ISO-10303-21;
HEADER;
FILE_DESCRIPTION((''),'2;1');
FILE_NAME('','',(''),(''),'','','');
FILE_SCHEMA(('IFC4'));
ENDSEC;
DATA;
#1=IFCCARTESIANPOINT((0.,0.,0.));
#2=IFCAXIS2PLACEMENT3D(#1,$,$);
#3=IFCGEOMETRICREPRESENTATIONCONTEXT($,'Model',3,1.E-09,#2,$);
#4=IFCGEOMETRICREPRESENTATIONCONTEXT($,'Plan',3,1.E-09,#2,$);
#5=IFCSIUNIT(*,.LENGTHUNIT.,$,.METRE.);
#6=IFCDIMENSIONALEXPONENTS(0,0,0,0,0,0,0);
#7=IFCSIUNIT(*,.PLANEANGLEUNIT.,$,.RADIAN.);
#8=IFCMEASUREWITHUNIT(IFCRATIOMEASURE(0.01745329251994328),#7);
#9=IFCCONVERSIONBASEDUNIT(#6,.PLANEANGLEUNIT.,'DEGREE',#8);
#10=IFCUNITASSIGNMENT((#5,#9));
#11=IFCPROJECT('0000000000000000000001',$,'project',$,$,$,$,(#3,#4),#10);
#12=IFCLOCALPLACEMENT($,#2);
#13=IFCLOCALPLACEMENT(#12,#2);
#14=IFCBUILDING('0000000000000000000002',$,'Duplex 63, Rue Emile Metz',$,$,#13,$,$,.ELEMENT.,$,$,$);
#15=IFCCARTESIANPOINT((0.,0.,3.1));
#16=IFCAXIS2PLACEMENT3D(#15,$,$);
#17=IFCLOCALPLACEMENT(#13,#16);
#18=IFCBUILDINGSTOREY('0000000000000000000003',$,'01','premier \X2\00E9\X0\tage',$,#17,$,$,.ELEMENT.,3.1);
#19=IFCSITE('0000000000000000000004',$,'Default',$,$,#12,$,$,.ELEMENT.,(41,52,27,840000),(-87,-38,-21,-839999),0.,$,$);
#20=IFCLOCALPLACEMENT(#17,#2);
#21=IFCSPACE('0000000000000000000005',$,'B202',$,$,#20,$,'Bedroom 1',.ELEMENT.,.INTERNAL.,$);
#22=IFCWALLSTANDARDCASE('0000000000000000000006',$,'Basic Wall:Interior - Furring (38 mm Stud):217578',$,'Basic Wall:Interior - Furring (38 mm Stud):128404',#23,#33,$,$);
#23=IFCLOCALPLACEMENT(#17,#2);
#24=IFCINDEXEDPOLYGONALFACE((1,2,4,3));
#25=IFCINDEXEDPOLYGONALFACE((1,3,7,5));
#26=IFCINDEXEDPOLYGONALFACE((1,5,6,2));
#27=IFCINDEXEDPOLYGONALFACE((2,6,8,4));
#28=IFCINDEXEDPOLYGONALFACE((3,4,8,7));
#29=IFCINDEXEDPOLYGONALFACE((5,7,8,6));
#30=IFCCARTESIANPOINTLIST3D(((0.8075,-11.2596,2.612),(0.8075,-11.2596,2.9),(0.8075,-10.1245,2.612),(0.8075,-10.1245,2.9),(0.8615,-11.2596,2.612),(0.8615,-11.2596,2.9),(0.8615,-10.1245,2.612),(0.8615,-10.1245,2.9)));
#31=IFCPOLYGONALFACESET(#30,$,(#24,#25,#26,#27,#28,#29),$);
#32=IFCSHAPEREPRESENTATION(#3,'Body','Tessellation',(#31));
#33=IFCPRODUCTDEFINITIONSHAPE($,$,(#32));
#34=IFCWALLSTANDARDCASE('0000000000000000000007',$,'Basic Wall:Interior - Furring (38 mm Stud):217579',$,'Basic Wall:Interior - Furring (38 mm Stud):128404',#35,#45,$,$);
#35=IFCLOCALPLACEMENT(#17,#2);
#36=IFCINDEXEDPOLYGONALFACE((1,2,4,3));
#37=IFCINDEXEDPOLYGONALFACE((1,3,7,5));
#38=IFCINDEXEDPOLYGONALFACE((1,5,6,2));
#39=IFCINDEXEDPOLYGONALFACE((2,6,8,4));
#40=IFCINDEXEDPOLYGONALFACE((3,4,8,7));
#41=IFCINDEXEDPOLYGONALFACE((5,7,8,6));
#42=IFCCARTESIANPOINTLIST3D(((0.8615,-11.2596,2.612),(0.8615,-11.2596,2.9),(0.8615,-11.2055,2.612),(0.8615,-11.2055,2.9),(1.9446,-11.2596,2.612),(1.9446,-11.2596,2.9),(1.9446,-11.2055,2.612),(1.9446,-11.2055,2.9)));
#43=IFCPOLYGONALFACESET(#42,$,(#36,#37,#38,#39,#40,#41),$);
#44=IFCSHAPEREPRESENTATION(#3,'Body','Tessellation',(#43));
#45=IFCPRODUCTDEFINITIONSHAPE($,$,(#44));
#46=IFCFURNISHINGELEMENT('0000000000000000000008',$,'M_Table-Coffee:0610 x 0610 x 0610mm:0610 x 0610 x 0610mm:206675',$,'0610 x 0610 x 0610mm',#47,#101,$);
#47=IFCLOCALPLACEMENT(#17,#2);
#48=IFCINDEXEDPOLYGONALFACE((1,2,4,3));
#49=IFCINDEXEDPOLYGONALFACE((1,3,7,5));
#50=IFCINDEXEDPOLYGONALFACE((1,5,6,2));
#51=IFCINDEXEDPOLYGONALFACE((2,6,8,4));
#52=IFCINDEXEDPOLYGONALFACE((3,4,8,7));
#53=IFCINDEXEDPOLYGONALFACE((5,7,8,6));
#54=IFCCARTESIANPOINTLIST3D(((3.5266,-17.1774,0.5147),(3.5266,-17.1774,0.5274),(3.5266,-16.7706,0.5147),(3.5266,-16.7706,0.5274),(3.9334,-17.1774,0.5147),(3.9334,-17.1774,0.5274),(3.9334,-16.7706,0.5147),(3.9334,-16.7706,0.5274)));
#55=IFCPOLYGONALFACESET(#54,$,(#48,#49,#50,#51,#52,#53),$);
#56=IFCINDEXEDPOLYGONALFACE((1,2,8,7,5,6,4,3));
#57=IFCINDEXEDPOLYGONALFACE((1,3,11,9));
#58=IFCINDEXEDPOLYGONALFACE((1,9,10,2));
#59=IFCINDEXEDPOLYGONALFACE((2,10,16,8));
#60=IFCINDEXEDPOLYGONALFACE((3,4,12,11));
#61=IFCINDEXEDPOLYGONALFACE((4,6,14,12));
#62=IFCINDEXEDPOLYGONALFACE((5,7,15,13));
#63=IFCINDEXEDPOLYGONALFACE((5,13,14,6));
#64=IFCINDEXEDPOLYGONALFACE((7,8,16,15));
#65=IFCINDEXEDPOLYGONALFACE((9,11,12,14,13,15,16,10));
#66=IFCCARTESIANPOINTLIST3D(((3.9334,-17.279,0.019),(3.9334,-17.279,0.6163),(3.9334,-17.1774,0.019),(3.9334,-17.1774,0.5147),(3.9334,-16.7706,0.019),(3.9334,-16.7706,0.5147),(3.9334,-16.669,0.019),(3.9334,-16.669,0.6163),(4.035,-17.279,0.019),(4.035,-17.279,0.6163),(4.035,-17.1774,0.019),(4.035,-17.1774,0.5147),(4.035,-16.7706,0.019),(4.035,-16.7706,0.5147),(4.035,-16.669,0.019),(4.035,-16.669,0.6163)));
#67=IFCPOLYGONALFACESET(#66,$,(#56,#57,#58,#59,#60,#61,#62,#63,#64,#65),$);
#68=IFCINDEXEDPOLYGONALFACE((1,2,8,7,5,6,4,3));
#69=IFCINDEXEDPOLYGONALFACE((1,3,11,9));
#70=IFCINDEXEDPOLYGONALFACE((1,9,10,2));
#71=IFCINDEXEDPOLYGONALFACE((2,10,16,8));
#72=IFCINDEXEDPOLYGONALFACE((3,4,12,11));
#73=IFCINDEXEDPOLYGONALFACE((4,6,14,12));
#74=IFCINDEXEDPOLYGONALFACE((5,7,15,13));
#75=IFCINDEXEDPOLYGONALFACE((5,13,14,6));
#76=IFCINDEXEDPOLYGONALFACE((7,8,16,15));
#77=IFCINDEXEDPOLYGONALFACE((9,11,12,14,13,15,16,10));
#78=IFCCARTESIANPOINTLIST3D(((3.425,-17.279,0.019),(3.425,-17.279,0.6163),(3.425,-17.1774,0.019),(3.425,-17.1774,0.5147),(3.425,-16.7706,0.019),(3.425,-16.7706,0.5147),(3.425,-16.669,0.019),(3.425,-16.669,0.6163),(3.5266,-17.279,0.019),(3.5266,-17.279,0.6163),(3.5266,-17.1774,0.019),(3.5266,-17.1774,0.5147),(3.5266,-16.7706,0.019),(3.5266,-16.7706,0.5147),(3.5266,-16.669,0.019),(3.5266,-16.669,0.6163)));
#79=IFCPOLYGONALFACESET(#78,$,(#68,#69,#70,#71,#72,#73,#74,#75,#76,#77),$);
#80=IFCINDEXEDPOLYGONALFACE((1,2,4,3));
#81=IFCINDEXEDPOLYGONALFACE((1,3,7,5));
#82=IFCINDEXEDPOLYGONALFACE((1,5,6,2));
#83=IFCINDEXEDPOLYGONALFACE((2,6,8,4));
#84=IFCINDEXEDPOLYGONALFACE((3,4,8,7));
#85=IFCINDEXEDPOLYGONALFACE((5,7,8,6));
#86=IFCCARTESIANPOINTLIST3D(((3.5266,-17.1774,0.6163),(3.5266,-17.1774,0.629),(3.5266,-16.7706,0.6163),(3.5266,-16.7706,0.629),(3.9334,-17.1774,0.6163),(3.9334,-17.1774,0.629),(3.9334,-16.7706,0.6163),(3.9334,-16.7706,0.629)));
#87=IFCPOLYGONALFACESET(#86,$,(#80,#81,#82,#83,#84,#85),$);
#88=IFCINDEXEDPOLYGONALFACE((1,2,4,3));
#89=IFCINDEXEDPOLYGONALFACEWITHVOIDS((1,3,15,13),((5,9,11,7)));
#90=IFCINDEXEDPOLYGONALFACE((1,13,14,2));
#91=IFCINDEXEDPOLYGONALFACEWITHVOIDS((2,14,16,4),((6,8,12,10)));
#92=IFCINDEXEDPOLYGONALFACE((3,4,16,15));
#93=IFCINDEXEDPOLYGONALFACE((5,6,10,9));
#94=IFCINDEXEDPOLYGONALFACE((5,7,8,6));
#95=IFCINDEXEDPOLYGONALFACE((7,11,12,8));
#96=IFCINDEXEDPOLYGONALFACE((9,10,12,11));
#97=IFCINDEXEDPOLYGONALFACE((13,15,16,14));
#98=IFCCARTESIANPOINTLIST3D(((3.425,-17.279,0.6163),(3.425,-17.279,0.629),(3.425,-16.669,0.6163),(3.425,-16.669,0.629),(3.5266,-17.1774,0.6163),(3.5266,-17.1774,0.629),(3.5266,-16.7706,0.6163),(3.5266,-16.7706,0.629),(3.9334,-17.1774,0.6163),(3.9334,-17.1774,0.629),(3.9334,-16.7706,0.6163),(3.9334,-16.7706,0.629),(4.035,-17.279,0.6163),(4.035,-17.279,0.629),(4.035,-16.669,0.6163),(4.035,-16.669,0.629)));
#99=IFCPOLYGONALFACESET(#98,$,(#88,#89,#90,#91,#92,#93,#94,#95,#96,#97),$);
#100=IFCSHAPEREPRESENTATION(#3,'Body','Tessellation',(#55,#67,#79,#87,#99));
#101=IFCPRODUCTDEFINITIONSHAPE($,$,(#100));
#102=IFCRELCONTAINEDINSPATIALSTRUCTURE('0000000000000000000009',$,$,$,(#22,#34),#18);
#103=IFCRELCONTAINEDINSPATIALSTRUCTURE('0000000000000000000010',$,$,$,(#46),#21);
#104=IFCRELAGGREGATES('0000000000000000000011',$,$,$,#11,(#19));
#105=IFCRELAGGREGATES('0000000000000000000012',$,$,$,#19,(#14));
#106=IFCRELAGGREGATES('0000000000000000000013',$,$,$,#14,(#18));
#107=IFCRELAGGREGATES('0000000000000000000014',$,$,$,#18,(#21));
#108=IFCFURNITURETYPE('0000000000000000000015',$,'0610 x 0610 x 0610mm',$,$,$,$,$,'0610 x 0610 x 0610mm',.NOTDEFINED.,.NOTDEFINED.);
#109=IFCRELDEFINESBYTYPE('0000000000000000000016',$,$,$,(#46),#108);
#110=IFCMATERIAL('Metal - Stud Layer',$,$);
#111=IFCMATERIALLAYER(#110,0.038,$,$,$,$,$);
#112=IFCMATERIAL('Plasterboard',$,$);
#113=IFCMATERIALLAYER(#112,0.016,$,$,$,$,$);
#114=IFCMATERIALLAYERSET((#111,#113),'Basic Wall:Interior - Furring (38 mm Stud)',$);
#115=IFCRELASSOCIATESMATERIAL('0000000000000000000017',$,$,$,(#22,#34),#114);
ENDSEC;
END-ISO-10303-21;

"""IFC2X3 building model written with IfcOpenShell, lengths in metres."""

from ifc_helpers import new_model, entity, si_unit, converted_unit, frame, frame_2d, origin, origin_2d_with_axis, place, context, project, spatial, polyline, rectangle, outline, extrude, source, transform, mapped, material, layer, layer_set, layer_usage, type_object, type_shapes, element, save


model = new_model("IFC2X3")

# Units and contexts
model_context = context("Model", 3, precision=1e-09, world=origin())
plan_context = context("Plan", 3, precision=1e-09, world=origin())
ifc_project = project(units=[si_unit("LENGTHUNIT", "METRE"), converted_unit("PLANEANGLEUNIT", "DEGREE", entity("IfcRatioMeasure", 0.01745329251994328), si_unit("PLANEANGLEUNIT", "RADIAN"), dimensions=[0, 0, 0, 0, 0, 0, 0])], contexts=[model_context, plan_context])

# Site, building, storey
site_placement = place(None, origin())
site = spatial("IfcSite", under=ifc_project, at=site_placement, Name="Default", CompositionType="ELEMENT", RefLatitude=(41, 52, 27, 840000), RefLongitude=(-87, -38, -21, -839999), RefElevation=0.0)
building_placement = place(site_placement, origin())
building = spatial("IfcBuilding", under=site, at=building_placement, Name="Duplex 63, Rue Emile Metz", CompositionType="ELEMENT")
storey_placement = place(building_placement, frame((0.0, 0.0, 3.1)))
storey = spatial("IfcBuildingStorey", under=building, at=storey_placement, Name="01", Description="premier étage", CompositionType="ELEMENT", Elevation=3.1)

# Shared definitions
ifc_material_1 = material(Name="Metal - Stud Layer")
ifc_material_2 = material(Name="Plasterboard")

# Walls
ifc_layer_1 = layer(ifc_material_1, 0.038)
ifc_layer_2 = layer(ifc_material_2, 0.016)
ifc_layer_set_1 = layer_set([ifc_layer_1, ifc_layer_2], Name="Basic Wall:Interior - Furring (38 mm Stud)")
ifc_layer_usage_1 = layer_usage(ifc_layer_set_1, "AXIS2", "NEGATIVE", 0.027)
wall_1_placement = place(storey_placement, frame((0.8345, -11.2596, 2.612), z_axis=(0.0, 0.0, 1.0), x_axis=(0.0, 1.0, 0.0)))
element("IfcWallStandardCase", 1, at=wall_1_placement, inside=storey, material=ifc_layer_usage_1, Name="Basic Wall:Interior - Furring (38 mm Stud):217578", ObjectType="Basic Wall:Interior - Furring (38 mm Stud):128404", context=model_context, shape_type="SweptSolid", body=[
    extrude(rectangle(XDim=1.1351, YDim=0.054, at=frame_2d((0.5675, 0.0), x_axis=(-1.0, 0.0))), origin(), (0.0, 0.0, 1.0), 0.288),
])
wall_2_placement = place(storey_placement, frame((1.9446, -11.2325, 2.612), z_axis=(0.0, 0.0, 1.0), x_axis=(-1.0, 0.0, 0.0)))
element("IfcWallStandardCase", 2, at=wall_2_placement, inside=storey, material=ifc_layer_usage_1, Name="Basic Wall:Interior - Furring (38 mm Stud):217579", ObjectType="Basic Wall:Interior - Furring (38 mm Stud):128404", context=model_context, shape_type="SweptSolid", body=[
    extrude(rectangle(XDim=1.0831, YDim=0.054, at=frame_2d((0.5415, 0.0), x_axis=(-1.0, 0.0))), origin(), (0.0, 0.0, 1.0), 0.288),
])

# Shared definitions
space_placement = place(storey_placement, origin())
space = spatial("IfcSpace", under=storey, at=space_placement, Name="B202", LongName="Bedroom 1", CompositionType="ELEMENT", InteriorOrExteriorSpace="INTERNAL")

# Furnishing element
furniture_type = type_object("IfcFurnitureType", Name="0610 x 0610 x 0610mm", ElementType="0610 x 0610 x 0610mm", AssemblyPlace="NOTDEFINED")
shared_shape_1 = source(origin(), model_context, "Body", "SweptSolid", [
    extrude(rectangle(XDim=0.4068, YDim=0.4068, at=origin_2d_with_axis()), frame((0.0183, 0.0952, 0.4957), z_axis=(0.0, 0.0, 1.0), x_axis=(-1.0, 0.0, 0.0)), (0.0, 0.0, 1.0), 0.0127),
    extrude(outline(polyline([(-0.2732, -0.305), (0.324, -0.305), (0.324, 0.305), (-0.2732, 0.305), (-0.2732, 0.2034), (0.2225, 0.2034), (0.2225, -0.2034), (-0.2732, -0.2034), (-0.2732, -0.305)])), frame((0.2217, 0.0952, 0.2732), z_axis=(1.0, 0.0, 0.0), x_axis=(0.0, 0.0, 1.0)), (0.0, 0.0, 1.0), 0.1016),
    extrude(outline(polyline([(-0.305, -0.3241), (0.305, -0.3241), (0.305, 0.2733), (0.2034, 0.2733), (0.2034, -0.2224), (-0.2034, -0.2224), (-0.2034, 0.2733), (-0.305, 0.2733), (-0.305, -0.3241)])), frame((-0.2867, 0.0952, 0.2733), z_axis=(1.0, 0.0, 0.0), x_axis=(0.0, -1.0, 0.0)), (0.0, 0.0, 1.0), 0.1016),
    extrude(rectangle(XDim=0.4068, YDim=0.4068, at=origin_2d_with_axis()), frame((0.0183, 0.0952, 0.5973), z_axis=(0.0, 0.0, 1.0), x_axis=(-1.0, 0.0, 0.0)), (0.0, 0.0, 1.0), 0.0127),
    extrude(outline(polyline([(-0.305, -0.305), (0.305, -0.305), (0.305, 0.305), (-0.305, 0.305), (-0.305, -0.305)]), holes=[polyline([(-0.2034, -0.2034), (-0.2034, 0.2034), (0.2034, 0.2034), (0.2034, -0.2034), (-0.2034, -0.2034)])]), frame((0.0183, 0.0952, 0.5973), z_axis=(0.0, 0.0, 1.0), x_axis=(-1.0, 0.0, 0.0)), (0.0, 0.0, 1.0), 0.0127),
])
type_shapes(furniture_type, [shared_shape_1])
furnishing_placement = place(space_placement, frame((3.7117, -17.0692, 0.019)))
element("IfcFurnishingElement", 3, at=furnishing_placement, inside=space, type_object=furniture_type, Name="M_Table-Coffee:0610 x 0610 x 0610mm:0610 x 0610 x 0610mm:206675", ObjectType="0610 x 0610 x 0610mm", context=model_context, shape_type="MappedRepresentation", body=[
    mapped(shared_shape_1, transform((0.0, 0.0, 0.0), scale=1.0)),
])

save(model, "model.ifc")
